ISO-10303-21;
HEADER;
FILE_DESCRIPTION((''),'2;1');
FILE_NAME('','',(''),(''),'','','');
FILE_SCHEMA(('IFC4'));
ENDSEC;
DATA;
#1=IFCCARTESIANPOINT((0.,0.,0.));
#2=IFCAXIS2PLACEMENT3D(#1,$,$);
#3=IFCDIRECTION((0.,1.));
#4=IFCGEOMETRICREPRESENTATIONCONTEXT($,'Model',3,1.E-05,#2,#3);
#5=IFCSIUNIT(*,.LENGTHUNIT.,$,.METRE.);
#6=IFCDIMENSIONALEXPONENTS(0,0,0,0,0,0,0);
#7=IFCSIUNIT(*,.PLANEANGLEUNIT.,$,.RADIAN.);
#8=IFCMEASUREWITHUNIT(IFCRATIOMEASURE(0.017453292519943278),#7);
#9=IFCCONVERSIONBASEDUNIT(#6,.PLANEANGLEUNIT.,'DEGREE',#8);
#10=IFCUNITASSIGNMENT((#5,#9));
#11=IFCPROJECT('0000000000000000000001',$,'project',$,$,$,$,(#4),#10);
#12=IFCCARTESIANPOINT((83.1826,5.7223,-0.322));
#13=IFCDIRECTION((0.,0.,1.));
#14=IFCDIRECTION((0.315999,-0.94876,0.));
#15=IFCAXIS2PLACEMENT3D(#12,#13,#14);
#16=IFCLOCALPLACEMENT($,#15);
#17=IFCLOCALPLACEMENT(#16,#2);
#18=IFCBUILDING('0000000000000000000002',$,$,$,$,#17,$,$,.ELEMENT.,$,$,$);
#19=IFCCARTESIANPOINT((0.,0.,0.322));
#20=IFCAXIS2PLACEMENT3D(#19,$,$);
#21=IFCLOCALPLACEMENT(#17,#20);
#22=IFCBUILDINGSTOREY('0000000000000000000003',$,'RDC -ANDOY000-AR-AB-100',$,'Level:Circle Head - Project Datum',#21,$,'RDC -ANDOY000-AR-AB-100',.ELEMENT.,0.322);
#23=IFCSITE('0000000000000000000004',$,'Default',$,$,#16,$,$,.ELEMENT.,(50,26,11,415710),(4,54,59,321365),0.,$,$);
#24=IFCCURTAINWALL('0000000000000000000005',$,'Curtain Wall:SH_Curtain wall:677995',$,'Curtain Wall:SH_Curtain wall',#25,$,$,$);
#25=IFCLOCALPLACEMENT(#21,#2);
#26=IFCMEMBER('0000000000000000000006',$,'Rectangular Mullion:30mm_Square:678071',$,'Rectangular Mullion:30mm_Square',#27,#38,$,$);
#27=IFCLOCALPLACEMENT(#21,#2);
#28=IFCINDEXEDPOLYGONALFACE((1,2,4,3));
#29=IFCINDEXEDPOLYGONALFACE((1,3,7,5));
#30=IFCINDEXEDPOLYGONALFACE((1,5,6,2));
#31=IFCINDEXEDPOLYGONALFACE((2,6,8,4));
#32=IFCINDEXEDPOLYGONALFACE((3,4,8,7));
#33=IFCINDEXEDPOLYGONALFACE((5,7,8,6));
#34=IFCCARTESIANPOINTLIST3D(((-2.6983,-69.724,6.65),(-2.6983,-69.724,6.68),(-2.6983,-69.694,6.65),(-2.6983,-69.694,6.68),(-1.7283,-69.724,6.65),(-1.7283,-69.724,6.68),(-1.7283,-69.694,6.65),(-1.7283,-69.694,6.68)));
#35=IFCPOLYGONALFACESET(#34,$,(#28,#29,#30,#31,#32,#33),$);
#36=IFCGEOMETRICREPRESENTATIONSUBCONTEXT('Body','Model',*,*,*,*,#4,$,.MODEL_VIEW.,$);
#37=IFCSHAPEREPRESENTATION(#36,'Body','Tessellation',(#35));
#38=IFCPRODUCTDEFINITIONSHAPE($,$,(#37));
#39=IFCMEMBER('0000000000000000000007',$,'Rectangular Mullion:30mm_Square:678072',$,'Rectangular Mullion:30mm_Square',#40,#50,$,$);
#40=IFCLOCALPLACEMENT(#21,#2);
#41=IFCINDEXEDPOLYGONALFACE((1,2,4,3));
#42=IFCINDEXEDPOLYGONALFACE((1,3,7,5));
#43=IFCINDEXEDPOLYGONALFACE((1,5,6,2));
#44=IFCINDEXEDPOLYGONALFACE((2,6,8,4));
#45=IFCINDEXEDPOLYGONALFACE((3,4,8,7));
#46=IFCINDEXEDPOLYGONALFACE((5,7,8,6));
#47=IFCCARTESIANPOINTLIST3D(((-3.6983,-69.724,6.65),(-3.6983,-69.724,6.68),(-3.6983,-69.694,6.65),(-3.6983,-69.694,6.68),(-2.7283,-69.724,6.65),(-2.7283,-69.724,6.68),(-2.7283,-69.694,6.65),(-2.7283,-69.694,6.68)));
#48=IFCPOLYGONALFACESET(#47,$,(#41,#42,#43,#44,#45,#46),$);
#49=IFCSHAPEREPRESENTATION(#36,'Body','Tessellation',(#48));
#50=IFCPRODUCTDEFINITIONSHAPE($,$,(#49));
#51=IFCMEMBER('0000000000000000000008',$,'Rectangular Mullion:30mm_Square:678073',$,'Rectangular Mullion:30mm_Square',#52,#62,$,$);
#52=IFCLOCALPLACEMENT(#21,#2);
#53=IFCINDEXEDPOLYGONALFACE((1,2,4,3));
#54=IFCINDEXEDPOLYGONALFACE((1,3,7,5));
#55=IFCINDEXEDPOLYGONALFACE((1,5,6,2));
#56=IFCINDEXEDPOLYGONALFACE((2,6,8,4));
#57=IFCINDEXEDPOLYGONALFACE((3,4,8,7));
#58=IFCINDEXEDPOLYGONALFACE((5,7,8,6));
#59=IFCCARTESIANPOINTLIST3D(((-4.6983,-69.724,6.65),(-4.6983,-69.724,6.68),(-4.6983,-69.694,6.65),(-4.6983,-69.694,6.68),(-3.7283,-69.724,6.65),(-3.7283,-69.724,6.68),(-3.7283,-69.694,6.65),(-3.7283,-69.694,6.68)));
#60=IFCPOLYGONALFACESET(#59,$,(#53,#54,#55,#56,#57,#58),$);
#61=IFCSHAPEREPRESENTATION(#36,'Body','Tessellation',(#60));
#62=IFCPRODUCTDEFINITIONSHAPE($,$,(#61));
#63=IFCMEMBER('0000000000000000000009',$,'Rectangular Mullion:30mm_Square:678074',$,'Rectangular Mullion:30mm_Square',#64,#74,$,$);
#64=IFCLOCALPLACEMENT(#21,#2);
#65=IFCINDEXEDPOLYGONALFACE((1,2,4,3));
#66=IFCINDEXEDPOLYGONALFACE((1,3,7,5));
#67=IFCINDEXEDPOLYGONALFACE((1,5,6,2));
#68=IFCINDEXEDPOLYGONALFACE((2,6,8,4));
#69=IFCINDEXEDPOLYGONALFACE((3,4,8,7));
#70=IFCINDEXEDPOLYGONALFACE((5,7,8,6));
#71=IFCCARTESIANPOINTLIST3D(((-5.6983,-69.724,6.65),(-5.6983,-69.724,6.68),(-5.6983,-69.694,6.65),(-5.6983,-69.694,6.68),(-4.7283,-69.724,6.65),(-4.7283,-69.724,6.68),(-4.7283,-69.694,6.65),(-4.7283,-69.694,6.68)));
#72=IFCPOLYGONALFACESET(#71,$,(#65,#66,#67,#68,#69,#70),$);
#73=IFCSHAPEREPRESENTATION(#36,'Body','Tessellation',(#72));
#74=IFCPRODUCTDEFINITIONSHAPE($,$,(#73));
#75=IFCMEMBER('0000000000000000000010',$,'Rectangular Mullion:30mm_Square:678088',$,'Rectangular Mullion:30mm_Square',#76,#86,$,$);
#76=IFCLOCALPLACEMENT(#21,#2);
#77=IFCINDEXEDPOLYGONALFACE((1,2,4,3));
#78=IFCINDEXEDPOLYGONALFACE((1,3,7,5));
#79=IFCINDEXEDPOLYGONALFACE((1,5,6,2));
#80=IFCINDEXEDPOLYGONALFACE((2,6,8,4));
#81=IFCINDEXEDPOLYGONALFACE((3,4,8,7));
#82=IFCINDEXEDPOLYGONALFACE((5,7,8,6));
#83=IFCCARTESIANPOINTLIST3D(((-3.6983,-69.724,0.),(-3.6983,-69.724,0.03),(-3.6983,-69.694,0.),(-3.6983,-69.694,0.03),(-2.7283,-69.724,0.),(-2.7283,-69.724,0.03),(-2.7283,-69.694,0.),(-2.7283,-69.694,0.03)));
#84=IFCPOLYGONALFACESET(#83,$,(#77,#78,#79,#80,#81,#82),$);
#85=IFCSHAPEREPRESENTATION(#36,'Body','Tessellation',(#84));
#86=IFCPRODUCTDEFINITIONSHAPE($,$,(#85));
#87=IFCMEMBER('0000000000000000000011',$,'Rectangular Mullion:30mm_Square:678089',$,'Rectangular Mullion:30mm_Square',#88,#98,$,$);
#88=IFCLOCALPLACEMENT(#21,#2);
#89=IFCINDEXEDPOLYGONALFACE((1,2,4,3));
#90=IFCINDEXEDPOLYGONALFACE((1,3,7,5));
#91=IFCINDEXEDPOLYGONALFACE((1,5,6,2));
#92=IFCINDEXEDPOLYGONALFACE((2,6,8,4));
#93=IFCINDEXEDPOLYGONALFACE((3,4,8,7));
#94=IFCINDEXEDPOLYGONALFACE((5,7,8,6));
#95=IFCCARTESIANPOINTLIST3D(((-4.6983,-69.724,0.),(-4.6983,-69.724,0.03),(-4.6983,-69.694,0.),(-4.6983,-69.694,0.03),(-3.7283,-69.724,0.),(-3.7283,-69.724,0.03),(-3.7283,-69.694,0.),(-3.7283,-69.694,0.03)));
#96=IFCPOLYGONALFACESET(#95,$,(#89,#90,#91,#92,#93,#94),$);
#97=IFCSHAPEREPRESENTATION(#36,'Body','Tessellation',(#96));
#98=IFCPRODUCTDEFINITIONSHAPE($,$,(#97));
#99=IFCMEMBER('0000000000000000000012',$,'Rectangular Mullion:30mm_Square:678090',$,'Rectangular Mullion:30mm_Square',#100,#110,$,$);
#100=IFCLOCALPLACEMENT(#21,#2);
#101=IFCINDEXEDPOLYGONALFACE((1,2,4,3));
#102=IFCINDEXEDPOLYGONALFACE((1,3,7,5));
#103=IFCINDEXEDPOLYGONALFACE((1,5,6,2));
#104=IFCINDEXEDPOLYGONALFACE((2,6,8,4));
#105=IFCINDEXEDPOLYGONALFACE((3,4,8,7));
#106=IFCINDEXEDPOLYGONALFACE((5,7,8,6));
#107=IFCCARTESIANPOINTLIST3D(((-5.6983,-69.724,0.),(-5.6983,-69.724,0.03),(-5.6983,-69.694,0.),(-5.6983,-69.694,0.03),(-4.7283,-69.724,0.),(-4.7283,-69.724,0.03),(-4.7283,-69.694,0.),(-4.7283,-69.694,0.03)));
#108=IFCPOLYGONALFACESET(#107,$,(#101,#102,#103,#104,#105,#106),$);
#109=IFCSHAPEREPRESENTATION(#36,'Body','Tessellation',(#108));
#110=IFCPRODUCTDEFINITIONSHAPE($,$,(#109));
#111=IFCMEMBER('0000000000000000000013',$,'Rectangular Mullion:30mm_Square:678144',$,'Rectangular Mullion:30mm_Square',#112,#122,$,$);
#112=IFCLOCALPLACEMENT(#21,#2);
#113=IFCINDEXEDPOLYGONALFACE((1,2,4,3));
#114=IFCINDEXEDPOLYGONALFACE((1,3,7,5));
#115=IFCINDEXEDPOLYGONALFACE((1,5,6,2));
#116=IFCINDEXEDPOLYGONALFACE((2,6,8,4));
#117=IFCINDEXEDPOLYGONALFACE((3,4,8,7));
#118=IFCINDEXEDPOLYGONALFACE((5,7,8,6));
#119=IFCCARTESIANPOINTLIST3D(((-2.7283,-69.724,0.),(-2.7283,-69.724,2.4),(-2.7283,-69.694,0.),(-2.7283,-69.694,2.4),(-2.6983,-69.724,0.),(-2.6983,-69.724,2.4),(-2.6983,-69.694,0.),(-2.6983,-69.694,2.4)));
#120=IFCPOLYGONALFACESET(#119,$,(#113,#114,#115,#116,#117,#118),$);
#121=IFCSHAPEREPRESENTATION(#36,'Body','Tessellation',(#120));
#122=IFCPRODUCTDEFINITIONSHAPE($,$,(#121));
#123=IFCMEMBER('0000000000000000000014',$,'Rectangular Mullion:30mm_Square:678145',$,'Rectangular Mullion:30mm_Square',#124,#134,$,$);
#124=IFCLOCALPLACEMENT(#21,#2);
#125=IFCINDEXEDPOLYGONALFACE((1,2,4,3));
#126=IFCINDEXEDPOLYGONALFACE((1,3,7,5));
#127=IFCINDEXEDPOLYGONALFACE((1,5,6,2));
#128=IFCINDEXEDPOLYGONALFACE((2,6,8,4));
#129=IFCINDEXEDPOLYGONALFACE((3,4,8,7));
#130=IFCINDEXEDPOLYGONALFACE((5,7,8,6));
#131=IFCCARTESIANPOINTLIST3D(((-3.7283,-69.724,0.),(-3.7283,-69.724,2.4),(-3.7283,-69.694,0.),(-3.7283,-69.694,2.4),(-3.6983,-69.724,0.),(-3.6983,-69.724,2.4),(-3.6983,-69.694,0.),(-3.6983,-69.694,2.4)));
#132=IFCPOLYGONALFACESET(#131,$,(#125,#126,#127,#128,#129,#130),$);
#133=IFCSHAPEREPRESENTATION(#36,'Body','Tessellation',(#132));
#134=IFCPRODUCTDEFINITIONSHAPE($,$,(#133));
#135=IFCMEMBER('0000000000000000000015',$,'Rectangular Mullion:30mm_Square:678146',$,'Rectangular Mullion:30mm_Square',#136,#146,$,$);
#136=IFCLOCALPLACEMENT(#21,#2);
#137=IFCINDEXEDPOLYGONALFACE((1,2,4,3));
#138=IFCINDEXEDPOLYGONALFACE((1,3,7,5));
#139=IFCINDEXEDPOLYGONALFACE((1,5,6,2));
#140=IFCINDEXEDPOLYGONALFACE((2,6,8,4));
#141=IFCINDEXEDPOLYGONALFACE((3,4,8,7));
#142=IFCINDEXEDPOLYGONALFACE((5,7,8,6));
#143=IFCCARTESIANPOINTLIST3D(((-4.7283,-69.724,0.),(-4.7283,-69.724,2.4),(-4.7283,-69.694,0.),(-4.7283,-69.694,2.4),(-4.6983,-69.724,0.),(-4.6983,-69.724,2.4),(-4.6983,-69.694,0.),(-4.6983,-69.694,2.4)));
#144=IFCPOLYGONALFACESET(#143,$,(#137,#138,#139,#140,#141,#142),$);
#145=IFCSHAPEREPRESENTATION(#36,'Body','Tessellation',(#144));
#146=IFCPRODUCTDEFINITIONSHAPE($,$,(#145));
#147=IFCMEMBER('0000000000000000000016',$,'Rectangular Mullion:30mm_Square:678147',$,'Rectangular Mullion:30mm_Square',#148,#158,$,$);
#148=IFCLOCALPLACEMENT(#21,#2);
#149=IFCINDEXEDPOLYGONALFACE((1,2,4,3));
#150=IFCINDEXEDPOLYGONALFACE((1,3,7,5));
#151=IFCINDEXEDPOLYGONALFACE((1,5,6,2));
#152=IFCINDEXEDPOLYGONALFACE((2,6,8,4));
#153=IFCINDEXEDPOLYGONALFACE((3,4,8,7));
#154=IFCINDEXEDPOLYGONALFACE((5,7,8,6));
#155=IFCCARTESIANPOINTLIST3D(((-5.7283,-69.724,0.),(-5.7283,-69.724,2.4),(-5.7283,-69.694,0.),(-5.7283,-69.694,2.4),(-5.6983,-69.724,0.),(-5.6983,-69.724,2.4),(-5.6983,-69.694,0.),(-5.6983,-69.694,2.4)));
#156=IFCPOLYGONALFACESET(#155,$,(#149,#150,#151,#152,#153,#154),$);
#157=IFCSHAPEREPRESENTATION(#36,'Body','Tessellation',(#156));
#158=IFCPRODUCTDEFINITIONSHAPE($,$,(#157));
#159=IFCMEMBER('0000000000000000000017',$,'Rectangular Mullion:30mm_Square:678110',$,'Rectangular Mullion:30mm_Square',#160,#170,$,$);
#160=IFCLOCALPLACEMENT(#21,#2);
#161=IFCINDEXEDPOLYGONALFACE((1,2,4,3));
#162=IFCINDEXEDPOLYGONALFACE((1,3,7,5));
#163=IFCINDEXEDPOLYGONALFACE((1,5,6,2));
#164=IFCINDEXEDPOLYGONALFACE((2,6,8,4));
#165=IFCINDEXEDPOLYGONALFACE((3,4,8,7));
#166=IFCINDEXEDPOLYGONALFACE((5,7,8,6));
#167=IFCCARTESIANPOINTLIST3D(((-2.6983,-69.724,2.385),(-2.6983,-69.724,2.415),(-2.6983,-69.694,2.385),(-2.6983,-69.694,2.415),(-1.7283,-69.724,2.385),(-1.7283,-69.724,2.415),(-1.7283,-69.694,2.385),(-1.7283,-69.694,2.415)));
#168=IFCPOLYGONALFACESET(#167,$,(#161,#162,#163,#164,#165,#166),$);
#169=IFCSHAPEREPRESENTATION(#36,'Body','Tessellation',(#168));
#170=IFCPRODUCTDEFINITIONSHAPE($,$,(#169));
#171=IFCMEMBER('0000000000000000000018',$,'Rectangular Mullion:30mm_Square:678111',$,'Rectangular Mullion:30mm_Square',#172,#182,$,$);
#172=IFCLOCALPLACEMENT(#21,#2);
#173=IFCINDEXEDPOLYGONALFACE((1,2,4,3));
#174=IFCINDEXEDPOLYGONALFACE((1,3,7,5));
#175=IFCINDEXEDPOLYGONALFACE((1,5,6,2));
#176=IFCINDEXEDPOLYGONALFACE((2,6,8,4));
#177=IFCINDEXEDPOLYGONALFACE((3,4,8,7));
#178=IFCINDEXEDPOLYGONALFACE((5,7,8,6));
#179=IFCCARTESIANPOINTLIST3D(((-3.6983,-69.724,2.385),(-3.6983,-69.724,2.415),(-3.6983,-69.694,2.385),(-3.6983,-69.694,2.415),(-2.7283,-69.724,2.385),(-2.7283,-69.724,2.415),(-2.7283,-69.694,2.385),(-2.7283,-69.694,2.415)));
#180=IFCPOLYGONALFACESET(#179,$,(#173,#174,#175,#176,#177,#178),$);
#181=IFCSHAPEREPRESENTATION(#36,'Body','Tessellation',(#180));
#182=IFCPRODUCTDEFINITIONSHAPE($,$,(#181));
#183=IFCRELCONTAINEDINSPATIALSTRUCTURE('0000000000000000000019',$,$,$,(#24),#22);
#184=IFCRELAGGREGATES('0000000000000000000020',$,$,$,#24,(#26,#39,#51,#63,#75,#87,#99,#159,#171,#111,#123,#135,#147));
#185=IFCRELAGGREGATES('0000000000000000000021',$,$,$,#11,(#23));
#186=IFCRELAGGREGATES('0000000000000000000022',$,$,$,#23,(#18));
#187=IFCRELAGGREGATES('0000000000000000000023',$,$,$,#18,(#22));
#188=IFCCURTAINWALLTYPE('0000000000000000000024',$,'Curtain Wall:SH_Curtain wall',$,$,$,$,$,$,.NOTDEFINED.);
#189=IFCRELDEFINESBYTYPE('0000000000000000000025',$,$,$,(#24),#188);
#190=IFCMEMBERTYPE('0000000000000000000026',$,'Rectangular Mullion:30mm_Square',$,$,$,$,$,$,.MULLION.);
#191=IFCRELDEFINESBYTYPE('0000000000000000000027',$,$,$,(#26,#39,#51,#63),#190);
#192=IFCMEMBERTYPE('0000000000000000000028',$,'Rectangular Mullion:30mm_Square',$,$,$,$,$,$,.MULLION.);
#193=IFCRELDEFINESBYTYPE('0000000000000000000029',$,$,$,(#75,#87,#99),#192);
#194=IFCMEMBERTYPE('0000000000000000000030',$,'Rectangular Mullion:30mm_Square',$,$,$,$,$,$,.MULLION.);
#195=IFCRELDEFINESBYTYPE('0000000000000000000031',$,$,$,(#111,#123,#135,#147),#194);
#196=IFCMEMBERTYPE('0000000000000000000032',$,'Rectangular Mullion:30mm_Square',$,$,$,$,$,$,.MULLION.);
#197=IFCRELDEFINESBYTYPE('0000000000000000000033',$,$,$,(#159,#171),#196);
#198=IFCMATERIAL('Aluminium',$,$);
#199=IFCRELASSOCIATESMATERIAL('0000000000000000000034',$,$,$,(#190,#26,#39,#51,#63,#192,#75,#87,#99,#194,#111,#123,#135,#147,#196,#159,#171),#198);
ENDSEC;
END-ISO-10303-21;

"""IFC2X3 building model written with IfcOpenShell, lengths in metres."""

from ifc_helpers import new_model, entity, si_unit, converted_unit, direction, frame, origin, origin_2d_with_axis, place, context, subcontext, project, spatial, rectangle, extrude, source, transform, mapped, material, type_object, type_shapes, element, aggregate, save


model = new_model("IFC2X3")

# Units and contexts
model_context = context("Model", 3, precision=1e-05, world=origin(), true_north=direction((0.0, 1.0)))
body_context = subcontext(model_context, "Body", "Model", "MODEL_VIEW")
ifc_project = project(units=[si_unit("LENGTHUNIT", "METRE"), converted_unit("PLANEANGLEUNIT", "DEGREE", entity("IfcRatioMeasure", 0.017453292519943278), si_unit("PLANEANGLEUNIT", "RADIAN"), dimensions=[0, 0, 0, 0, 0, 0, 0])], contexts=[model_context])

# Site, building, storey
site_placement = place(None, frame((83.1826, 5.7223, -0.322), z_axis=(0.0, 0.0, 1.0), x_axis=(0.315999, -0.94876, 0.0)))
site = spatial("IfcSite", under=ifc_project, at=site_placement, Name="Default", CompositionType="ELEMENT", RefLatitude=(50, 26, 11, 415710), RefLongitude=(4, 54, 59, 321365), RefElevation=0.0)
building_placement = place(site_placement, origin())
building = spatial("IfcBuilding", under=site, at=building_placement, CompositionType="ELEMENT")
storey_placement = place(building_placement, frame((0.0, 0.0, 0.322)))
storey = spatial("IfcBuildingStorey", under=building, at=storey_placement, Name="RDC -ANDOY000-AR-AB-100", ObjectType="Level:Circle Head - Project Datum", LongName="RDC -ANDOY000-AR-AB-100", CompositionType="ELEMENT", Elevation=0.322)

# Curtain wall, members
curtain_wall_type = type_object("IfcCurtainWallType", Name="Curtain Wall:SH_Curtain wall", PredefinedType="NOTDEFINED")
curtain_wall_placement = place(storey_placement, frame((0.0, 0.0, -0.322)))
curtain_wall = element("IfcCurtainWall", 1, at=curtain_wall_placement, inside=storey, type_object=curtain_wall_type, Name="Curtain Wall:SH_Curtain wall:677995", ObjectType="Curtain Wall:SH_Curtain wall")
ifc_material_1 = material(Name="Aluminium")
member_type_1 = type_object("IfcMemberType", Name="Rectangular Mullion:30mm_Square", PredefinedType="MULLION", material=ifc_material_1)
shared_shape_1 = source(origin(), body_context, "Body", "SweptSolid", [
    extrude(rectangle(XDim=0.03, YDim=0.03, at=origin_2d_with_axis()), frame((-0.015, 0.0, -0.97), z_axis=(0.0, 0.0, 1.0), x_axis=(0.0, -1.0, 0.0)), (0.0, 0.0, 1.0), 0.97),
])
type_shapes(member_type_1, [shared_shape_1])
member_1_placement = place(curtain_wall_placement, frame((-2.6983, -69.709, 7.002), z_axis=(-1.0, 0.0, 0.0), x_axis=(0.0, 0.0, 1.0)))
member_1 = element("IfcMember", 2, at=member_1_placement, type_object=member_type_1, material=ifc_material_1, Name="Rectangular Mullion:30mm_Square:678071", ObjectType="Rectangular Mullion:30mm_Square", context=body_context, shape_type="MappedRepresentation", body=[
    mapped(shared_shape_1, transform((0.0, 0.0, 0.0), scale=1.0)),
])
member_2_placement = place(curtain_wall_placement, frame((-3.6983, -69.709, 7.002), z_axis=(-1.0, 0.0, 0.0), x_axis=(0.0, 0.0, 1.0)))
member_2 = element("IfcMember", 3, at=member_2_placement, type_object=member_type_1, material=ifc_material_1, Name="Rectangular Mullion:30mm_Square:678072", ObjectType="Rectangular Mullion:30mm_Square", context=body_context, shape_type="MappedRepresentation", body=[
    mapped(shared_shape_1, transform((0.0, 0.0, 0.0), scale=1.0)),
])
member_3_placement = place(curtain_wall_placement, frame((-4.6983, -69.709, 7.002), z_axis=(-1.0, 0.0, 0.0), x_axis=(0.0, 0.0, 1.0)))
member_3 = element("IfcMember", 4, at=member_3_placement, type_object=member_type_1, material=ifc_material_1, Name="Rectangular Mullion:30mm_Square:678073", ObjectType="Rectangular Mullion:30mm_Square", context=body_context, shape_type="MappedRepresentation", body=[
    mapped(shared_shape_1, transform((0.0, 0.0, 0.0), scale=1.0)),
])
member_4_placement = place(curtain_wall_placement, frame((-5.6983, -69.709, 7.002), z_axis=(-1.0, 0.0, 0.0), x_axis=(0.0, 0.0, 1.0)))
member_4 = element("IfcMember", 5, at=member_4_placement, type_object=member_type_1, material=ifc_material_1, Name="Rectangular Mullion:30mm_Square:678074", ObjectType="Rectangular Mullion:30mm_Square", context=body_context, shape_type="MappedRepresentation", body=[
    mapped(shared_shape_1, transform((0.0, 0.0, 0.0), scale=1.0)),
])
member_type_2 = type_object("IfcMemberType", Name="Rectangular Mullion:30mm_Square", PredefinedType="MULLION", material=ifc_material_1)
shared_shape_2 = source(origin(), body_context, "Body", "SweptSolid", [
    extrude(rectangle(XDim=0.03, YDim=0.03, at=origin_2d_with_axis()), frame((-0.015, 0.0, -0.97), z_axis=(0.0, 0.0, 1.0), x_axis=(0.0, -1.0, 0.0)), (0.0, 0.0, 1.0), 0.97),
])
type_shapes(member_type_2, [shared_shape_2])
member_5_placement = place(curtain_wall_placement, frame((-2.7283, -69.709, 0.322), z_axis=(1.0, 0.0, 0.0), x_axis=(0.0, 0.0, -1.0)))
member_5 = element("IfcMember", 6, at=member_5_placement, type_object=member_type_2, material=ifc_material_1, Name="Rectangular Mullion:30mm_Square:678088", ObjectType="Rectangular Mullion:30mm_Square", context=body_context, shape_type="MappedRepresentation", body=[
    mapped(shared_shape_2, transform((0.0, 0.0, 0.0), scale=1.0)),
])
member_6_placement = place(curtain_wall_placement, frame((-3.7283, -69.709, 0.322), z_axis=(1.0, 0.0, 0.0), x_axis=(0.0, 0.0, -1.0)))
member_6 = element("IfcMember", 7, at=member_6_placement, type_object=member_type_2, material=ifc_material_1, Name="Rectangular Mullion:30mm_Square:678089", ObjectType="Rectangular Mullion:30mm_Square", context=body_context, shape_type="MappedRepresentation", body=[
    mapped(shared_shape_2, transform((0.0, 0.0, 0.0), scale=1.0)),
])
member_7_placement = place(curtain_wall_placement, frame((-4.7283, -69.709, 0.322), z_axis=(1.0, 0.0, 0.0), x_axis=(0.0, 0.0, -1.0)))
member_7 = element("IfcMember", 8, at=member_7_placement, type_object=member_type_2, material=ifc_material_1, Name="Rectangular Mullion:30mm_Square:678090", ObjectType="Rectangular Mullion:30mm_Square", context=body_context, shape_type="MappedRepresentation", body=[
    mapped(shared_shape_2, transform((0.0, 0.0, 0.0), scale=1.0)),
])
member_type_3 = type_object("IfcMemberType", Name="Rectangular Mullion:30mm_Square", PredefinedType="MULLION", material=ifc_material_1)
shared_shape_3 = source(origin(), body_context, "Body", "SweptSolid", [
    extrude(rectangle(XDim=0.03, YDim=0.03, at=origin_2d_with_axis()), frame((0.0, 0.0, -2.4), z_axis=(0.0, 0.0, 1.0), x_axis=(0.0, -1.0, 0.0)), (0.0, 0.0, 1.0), 2.4),
])
type_shapes(member_type_3, [shared_shape_3])
member_8_placement = place(curtain_wall_placement, frame((-2.7133, -69.709, 0.322), z_axis=(0.0, 0.0, -1.0), x_axis=(-1.0, 0.0, 0.0)))
member_8 = element("IfcMember", 9, at=member_8_placement, type_object=member_type_3, material=ifc_material_1, Name="Rectangular Mullion:30mm_Square:678144", ObjectType="Rectangular Mullion:30mm_Square", context=body_context, shape_type="MappedRepresentation", body=[
    mapped(shared_shape_3, transform((0.0, 0.0, 0.0), scale=1.0)),
])
member_9_placement = place(curtain_wall_placement, frame((-3.7133, -69.709, 0.322), z_axis=(0.0, 0.0, -1.0), x_axis=(-1.0, 0.0, 0.0)))
member_9 = element("IfcMember", 10, at=member_9_placement, type_object=member_type_3, material=ifc_material_1, Name="Rectangular Mullion:30mm_Square:678145", ObjectType="Rectangular Mullion:30mm_Square", context=body_context, shape_type="MappedRepresentation", body=[
    mapped(shared_shape_3, transform((0.0, 0.0, 0.0), scale=1.0)),
])
member_10_placement = place(curtain_wall_placement, frame((-4.7133, -69.709, 0.322), z_axis=(0.0, 0.0, -1.0), x_axis=(-1.0, 0.0, 0.0)))
member_10 = element("IfcMember", 11, at=member_10_placement, type_object=member_type_3, material=ifc_material_1, Name="Rectangular Mullion:30mm_Square:678146", ObjectType="Rectangular Mullion:30mm_Square", context=body_context, shape_type="MappedRepresentation", body=[
    mapped(shared_shape_3, transform((0.0, 0.0, 0.0), scale=1.0)),
])
member_11_placement = place(curtain_wall_placement, frame((-5.7133, -69.709, 0.322), z_axis=(0.0, 0.0, -1.0), x_axis=(-1.0, 0.0, 0.0)))
member_11 = element("IfcMember", 12, at=member_11_placement, type_object=member_type_3, material=ifc_material_1, Name="Rectangular Mullion:30mm_Square:678147", ObjectType="Rectangular Mullion:30mm_Square", context=body_context, shape_type="MappedRepresentation", body=[
    mapped(shared_shape_3, transform((0.0, 0.0, 0.0), scale=1.0)),
])
member_type_4 = type_object("IfcMemberType", Name="Rectangular Mullion:30mm_Square", PredefinedType="MULLION", material=ifc_material_1)
shared_shape_4 = source(origin(), body_context, "Body", "SweptSolid", [
    extrude(rectangle(XDim=0.03, YDim=0.03, at=origin_2d_with_axis()), frame((0.0, 0.0, -0.97), z_axis=(0.0, 0.0, 1.0), x_axis=(0.0, -1.0, 0.0)), (0.0, 0.0, 1.0), 0.97),
])
type_shapes(member_type_4, [shared_shape_4])
member_12_placement = place(curtain_wall_placement, frame((-2.6983, -69.709, 2.722), z_axis=(-1.0, 0.0, 0.0), x_axis=(0.0, 0.0, 1.0)))
member_12 = element("IfcMember", 13, at=member_12_placement, type_object=member_type_4, material=ifc_material_1, Name="Rectangular Mullion:30mm_Square:678110", ObjectType="Rectangular Mullion:30mm_Square", context=body_context, shape_type="MappedRepresentation", body=[
    mapped(shared_shape_4, transform((0.0, 0.0, 0.0), scale=1.0)),
])
member_13_placement = place(curtain_wall_placement, frame((-3.6983, -69.709, 2.722), z_axis=(-1.0, 0.0, 0.0), x_axis=(0.0, 0.0, 1.0)))
member_13 = element("IfcMember", 14, at=member_13_placement, type_object=member_type_4, material=ifc_material_1, Name="Rectangular Mullion:30mm_Square:678111", ObjectType="Rectangular Mullion:30mm_Square", context=body_context, shape_type="MappedRepresentation", body=[
    mapped(shared_shape_4, transform((0.0, 0.0, 0.0), scale=1.0)),
])
aggregate(curtain_wall, [member_1, member_2, member_3, member_4, member_5, member_6, member_7, member_12, member_13, member_8, member_9, member_10, member_11])

save(model, "model.ifc")
